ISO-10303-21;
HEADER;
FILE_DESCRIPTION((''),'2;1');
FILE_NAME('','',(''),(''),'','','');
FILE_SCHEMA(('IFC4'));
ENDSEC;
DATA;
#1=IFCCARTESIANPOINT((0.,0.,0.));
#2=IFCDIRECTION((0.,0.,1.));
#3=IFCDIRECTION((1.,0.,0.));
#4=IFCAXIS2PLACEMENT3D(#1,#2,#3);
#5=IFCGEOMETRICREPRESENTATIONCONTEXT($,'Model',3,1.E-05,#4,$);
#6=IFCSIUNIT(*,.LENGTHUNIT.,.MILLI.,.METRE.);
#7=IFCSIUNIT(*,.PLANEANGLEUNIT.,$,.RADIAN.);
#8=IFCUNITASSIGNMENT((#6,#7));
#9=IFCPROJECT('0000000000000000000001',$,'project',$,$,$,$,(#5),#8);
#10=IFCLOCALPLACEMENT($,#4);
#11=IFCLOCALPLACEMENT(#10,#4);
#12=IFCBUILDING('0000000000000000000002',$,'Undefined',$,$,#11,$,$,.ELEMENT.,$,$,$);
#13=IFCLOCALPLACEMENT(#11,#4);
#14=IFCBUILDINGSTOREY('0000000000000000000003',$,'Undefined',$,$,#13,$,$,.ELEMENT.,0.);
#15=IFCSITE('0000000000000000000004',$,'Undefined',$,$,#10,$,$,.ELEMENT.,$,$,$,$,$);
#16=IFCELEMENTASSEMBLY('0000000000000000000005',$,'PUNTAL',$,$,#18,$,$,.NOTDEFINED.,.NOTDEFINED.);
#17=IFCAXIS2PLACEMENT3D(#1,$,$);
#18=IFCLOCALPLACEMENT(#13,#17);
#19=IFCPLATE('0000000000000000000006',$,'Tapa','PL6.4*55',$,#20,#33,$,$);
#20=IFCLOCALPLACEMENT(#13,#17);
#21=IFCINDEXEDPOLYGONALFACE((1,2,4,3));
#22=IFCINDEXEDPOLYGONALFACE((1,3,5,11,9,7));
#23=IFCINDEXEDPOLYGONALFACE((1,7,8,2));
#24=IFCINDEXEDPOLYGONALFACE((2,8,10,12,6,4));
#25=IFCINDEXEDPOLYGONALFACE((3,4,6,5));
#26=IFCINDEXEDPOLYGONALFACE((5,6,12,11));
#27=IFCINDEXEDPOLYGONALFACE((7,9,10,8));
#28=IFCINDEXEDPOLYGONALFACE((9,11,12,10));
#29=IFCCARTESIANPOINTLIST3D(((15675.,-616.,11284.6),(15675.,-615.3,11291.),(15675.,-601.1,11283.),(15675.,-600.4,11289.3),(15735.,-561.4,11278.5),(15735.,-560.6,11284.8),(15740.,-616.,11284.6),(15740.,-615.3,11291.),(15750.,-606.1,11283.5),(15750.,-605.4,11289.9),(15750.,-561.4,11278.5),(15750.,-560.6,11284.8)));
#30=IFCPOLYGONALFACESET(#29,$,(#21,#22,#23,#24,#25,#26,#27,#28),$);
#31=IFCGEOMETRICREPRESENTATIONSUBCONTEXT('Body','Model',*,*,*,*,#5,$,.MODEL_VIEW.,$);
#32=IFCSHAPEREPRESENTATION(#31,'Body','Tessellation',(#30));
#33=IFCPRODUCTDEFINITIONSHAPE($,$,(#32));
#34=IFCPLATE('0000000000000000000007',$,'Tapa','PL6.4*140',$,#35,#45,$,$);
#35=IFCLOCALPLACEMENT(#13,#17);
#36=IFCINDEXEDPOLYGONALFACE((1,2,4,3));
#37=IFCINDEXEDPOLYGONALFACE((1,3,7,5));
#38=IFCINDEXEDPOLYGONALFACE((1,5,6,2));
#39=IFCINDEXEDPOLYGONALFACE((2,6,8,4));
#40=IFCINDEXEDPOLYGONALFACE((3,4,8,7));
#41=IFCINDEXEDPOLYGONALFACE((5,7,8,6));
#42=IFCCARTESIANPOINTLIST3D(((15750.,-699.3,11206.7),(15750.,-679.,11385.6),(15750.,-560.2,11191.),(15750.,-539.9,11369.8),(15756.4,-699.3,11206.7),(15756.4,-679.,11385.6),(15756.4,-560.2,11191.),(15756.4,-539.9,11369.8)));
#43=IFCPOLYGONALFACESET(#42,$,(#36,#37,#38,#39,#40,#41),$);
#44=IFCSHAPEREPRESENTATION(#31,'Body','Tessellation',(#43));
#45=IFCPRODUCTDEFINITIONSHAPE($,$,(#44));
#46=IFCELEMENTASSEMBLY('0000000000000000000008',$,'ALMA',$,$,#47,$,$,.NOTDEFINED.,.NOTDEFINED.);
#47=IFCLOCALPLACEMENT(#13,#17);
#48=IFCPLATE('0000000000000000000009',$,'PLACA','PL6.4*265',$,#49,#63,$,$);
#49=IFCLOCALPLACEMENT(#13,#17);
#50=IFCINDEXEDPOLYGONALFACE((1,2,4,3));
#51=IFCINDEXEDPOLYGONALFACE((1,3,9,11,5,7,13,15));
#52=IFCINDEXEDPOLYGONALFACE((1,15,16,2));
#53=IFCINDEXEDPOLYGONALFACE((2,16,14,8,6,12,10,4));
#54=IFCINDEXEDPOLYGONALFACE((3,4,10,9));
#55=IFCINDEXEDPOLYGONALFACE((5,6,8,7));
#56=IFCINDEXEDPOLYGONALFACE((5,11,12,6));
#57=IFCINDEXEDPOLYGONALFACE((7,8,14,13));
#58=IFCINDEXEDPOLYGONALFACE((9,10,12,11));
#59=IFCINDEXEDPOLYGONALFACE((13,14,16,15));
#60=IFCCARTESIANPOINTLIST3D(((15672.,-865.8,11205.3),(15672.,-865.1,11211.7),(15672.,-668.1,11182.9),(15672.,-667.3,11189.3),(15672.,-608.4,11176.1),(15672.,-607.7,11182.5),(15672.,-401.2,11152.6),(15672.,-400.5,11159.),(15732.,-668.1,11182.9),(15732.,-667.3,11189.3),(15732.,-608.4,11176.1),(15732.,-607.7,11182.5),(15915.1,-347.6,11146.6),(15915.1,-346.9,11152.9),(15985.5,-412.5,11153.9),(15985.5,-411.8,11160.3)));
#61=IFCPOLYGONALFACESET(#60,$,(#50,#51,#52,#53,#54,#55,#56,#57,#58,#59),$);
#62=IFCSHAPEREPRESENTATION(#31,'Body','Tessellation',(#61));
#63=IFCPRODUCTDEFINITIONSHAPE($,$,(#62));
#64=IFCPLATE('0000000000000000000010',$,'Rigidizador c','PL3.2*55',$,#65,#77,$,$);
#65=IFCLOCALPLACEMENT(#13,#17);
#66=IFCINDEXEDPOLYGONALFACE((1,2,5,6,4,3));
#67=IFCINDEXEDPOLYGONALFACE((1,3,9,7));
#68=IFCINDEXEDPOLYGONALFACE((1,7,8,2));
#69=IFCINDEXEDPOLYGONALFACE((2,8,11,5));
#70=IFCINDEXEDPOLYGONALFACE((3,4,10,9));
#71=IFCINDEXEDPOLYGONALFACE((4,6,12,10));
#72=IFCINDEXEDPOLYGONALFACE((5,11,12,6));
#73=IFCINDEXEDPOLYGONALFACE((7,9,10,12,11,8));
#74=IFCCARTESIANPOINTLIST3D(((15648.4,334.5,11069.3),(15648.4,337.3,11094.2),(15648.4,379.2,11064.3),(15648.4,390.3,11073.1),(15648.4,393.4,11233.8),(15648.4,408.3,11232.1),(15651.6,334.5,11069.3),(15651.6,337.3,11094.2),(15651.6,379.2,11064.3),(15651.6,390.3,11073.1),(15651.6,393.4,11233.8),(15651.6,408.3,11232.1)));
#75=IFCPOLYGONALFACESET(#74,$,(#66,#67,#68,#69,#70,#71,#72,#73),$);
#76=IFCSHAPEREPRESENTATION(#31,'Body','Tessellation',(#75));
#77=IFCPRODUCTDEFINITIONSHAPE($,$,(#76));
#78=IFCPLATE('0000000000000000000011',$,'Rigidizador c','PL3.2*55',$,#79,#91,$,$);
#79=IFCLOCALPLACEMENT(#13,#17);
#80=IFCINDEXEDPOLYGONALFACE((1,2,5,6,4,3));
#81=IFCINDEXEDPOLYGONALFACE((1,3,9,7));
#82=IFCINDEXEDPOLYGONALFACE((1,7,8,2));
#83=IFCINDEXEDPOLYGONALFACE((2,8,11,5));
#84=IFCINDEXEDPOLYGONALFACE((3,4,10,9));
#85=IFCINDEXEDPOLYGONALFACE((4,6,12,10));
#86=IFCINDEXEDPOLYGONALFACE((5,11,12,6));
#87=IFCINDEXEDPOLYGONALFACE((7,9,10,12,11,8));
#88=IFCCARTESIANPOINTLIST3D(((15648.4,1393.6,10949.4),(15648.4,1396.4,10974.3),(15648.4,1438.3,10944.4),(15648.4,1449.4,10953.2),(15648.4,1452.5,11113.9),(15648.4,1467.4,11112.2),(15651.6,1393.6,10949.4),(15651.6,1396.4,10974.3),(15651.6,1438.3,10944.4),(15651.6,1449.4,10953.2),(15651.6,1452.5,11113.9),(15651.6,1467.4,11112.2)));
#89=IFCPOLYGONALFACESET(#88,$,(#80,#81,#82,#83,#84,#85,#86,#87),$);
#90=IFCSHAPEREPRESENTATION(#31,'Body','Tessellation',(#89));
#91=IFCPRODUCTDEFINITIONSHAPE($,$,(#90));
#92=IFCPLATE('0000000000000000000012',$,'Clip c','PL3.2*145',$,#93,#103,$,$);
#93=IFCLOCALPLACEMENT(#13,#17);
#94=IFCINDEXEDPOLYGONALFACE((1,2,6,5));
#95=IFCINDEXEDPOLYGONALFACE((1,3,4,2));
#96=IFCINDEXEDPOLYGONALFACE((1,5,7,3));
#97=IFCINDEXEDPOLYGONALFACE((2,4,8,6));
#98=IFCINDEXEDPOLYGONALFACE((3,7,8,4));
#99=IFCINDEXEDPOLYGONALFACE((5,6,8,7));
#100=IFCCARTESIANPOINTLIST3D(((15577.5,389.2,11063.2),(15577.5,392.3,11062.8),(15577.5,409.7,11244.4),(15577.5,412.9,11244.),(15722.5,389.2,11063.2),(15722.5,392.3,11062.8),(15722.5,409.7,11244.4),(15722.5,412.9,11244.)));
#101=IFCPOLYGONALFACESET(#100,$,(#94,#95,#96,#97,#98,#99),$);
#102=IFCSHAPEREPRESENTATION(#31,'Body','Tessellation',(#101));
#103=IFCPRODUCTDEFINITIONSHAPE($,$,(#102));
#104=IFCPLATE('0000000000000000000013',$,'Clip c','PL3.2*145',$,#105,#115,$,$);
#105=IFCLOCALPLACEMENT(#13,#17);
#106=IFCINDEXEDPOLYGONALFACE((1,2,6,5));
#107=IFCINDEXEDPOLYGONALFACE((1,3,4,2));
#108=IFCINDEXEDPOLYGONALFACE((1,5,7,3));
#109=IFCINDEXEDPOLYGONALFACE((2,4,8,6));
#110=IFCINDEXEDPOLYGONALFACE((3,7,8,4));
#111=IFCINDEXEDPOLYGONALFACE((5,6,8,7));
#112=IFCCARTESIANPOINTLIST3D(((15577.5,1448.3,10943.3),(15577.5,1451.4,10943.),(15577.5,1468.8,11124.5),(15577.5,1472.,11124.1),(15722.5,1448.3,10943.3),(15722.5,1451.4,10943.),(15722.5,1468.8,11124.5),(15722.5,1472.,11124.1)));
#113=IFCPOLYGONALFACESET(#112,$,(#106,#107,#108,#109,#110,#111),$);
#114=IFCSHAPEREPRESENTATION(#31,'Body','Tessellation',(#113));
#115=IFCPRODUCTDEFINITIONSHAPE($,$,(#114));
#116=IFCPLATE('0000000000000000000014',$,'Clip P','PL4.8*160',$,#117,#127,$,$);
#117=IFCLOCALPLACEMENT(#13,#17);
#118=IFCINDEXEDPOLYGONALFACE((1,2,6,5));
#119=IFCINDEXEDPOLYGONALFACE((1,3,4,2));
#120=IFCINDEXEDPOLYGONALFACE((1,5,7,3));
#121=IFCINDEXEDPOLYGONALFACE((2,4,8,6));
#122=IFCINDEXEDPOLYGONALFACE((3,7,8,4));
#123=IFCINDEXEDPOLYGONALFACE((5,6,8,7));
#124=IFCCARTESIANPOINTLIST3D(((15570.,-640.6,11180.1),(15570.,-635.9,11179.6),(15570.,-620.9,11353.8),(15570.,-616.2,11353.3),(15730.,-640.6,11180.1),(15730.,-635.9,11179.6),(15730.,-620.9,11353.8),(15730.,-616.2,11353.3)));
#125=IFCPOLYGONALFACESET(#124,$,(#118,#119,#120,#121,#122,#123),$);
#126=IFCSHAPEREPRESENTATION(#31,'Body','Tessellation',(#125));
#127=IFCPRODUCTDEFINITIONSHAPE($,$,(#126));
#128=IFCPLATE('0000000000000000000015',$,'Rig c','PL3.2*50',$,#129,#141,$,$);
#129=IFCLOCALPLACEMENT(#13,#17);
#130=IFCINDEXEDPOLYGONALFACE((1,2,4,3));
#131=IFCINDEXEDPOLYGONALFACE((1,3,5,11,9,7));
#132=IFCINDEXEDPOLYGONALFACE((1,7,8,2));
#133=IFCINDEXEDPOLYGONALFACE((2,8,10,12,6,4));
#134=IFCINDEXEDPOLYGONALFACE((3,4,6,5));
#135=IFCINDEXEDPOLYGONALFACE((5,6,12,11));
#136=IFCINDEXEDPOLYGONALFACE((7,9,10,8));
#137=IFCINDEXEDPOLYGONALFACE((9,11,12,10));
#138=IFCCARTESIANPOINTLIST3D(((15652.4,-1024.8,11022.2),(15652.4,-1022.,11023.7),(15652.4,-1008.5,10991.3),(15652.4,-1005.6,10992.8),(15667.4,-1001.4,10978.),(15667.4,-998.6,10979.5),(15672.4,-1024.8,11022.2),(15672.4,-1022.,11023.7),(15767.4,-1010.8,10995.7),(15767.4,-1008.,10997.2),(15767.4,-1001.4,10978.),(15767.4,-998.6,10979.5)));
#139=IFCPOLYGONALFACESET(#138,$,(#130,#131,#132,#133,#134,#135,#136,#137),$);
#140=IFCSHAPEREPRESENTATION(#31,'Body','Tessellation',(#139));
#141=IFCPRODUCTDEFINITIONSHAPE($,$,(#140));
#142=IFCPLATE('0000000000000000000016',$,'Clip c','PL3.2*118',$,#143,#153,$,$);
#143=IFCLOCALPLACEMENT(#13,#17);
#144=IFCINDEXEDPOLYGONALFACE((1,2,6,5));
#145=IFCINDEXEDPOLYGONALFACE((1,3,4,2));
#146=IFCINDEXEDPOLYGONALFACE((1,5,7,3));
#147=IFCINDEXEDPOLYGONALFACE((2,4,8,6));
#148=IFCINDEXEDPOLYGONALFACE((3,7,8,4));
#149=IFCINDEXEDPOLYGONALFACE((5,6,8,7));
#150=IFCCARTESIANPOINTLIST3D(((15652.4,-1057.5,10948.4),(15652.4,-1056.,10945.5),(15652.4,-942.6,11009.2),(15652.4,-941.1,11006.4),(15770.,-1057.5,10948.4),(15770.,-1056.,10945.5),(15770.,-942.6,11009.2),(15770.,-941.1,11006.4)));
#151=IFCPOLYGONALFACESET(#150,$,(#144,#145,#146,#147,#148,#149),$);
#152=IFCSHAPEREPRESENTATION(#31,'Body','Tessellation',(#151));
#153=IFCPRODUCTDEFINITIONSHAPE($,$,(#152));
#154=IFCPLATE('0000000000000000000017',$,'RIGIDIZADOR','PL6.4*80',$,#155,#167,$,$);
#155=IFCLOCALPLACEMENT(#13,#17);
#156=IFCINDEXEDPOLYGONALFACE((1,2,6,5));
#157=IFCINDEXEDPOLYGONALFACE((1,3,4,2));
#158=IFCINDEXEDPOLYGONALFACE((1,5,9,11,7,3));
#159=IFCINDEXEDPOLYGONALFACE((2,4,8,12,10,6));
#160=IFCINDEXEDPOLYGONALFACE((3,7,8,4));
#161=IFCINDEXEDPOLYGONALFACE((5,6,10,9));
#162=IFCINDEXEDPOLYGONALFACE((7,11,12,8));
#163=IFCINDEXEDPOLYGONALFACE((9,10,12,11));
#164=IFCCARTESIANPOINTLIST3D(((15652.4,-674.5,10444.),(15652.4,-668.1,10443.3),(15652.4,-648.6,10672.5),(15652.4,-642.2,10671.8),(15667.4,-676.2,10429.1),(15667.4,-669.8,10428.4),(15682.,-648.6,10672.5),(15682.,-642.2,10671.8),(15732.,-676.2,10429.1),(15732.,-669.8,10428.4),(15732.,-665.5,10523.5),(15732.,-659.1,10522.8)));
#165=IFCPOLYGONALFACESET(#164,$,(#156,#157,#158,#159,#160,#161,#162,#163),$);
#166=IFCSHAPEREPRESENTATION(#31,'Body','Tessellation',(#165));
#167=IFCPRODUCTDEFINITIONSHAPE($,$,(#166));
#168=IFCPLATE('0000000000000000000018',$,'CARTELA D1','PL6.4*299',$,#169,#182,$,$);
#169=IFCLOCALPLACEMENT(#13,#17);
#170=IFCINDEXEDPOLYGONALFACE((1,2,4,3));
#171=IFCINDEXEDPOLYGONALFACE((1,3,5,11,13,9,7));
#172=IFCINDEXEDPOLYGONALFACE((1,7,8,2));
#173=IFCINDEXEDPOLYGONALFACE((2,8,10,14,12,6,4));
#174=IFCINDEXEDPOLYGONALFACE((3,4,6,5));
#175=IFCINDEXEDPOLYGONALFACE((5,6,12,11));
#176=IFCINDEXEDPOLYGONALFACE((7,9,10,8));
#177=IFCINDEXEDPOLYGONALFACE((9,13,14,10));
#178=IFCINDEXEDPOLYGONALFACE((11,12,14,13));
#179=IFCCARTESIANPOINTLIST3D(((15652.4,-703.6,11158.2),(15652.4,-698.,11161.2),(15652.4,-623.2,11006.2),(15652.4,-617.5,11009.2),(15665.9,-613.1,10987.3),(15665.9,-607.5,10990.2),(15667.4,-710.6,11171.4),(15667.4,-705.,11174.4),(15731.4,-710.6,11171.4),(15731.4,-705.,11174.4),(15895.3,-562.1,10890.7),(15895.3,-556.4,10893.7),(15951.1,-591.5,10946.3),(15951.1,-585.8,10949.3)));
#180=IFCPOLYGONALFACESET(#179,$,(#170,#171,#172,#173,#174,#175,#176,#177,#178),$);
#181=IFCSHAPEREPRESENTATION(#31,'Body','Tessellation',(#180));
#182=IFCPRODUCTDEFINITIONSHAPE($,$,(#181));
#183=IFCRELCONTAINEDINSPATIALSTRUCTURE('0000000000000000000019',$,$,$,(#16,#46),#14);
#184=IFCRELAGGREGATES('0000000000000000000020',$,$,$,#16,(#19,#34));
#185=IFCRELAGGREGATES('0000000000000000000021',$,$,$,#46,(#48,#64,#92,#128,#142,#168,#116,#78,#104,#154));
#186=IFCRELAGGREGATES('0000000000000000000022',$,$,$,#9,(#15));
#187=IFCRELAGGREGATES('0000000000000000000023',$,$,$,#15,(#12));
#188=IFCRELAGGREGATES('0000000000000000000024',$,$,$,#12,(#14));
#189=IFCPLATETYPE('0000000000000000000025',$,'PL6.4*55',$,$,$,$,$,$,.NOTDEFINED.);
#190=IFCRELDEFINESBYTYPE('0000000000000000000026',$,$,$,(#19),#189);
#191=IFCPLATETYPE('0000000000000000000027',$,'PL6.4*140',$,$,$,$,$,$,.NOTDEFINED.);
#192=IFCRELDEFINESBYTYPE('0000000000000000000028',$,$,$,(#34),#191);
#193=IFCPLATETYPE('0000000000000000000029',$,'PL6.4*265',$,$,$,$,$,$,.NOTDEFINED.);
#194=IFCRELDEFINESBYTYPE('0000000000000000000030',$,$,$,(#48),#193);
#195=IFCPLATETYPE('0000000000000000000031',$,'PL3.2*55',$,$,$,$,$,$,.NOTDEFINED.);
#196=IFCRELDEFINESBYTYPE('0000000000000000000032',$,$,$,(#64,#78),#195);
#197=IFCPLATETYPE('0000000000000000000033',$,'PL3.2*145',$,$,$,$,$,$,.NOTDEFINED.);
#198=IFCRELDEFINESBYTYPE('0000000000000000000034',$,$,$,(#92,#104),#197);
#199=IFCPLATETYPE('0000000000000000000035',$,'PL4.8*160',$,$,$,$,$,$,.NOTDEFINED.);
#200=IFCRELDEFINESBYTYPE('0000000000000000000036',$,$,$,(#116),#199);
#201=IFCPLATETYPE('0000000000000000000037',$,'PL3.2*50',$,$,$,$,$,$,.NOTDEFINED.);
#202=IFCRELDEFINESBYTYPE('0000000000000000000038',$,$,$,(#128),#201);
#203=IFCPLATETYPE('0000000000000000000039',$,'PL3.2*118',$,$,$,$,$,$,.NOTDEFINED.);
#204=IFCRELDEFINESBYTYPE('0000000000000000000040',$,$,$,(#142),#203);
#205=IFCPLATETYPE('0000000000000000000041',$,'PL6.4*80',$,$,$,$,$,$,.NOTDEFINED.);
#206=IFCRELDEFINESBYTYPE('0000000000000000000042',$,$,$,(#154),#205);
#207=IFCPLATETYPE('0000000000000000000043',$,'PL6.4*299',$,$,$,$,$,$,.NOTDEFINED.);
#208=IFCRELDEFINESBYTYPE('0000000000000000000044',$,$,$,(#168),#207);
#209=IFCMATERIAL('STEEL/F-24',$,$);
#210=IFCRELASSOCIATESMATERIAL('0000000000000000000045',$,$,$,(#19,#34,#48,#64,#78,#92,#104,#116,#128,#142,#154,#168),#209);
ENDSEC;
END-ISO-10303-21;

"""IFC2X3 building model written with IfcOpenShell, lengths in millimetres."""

from ifc_helpers import new_model, si_unit, frame, origin_with_axes, place, context, subcontext, project, spatial, polyline, outline, extrude, boolean, material, type_object, element, aggregate, save


model = new_model("IFC2X3")

# Units and contexts
model_context = context("Model", 3, precision=1e-05, world=origin_with_axes())
body_context = subcontext(model_context, "Body", "Model", "MODEL_VIEW")
ifc_project = project(units=[si_unit("LENGTHUNIT", "METRE", prefix="MILLI"), si_unit("PLANEANGLEUNIT", "RADIAN")], contexts=[model_context])

# Site, building, storey
site_placement = place(None, origin_with_axes())
site = spatial("IfcSite", under=ifc_project, at=site_placement, Name="Undefined", CompositionType="ELEMENT")
building_placement = place(site_placement, origin_with_axes())
building = spatial("IfcBuilding", under=site, at=building_placement, Name="Undefined", CompositionType="ELEMENT")
storey_placement = place(building_placement, origin_with_axes())
storey = spatial("IfcBuildingStorey", under=building, at=storey_placement, Name="Undefined", CompositionType="ELEMENT", Elevation=0.0)

# Shared definitions
ifc_material_1 = material(Name="STEEL/F-24")

# Element assemblies, plates
assembly_1_placement = place(storey_placement, origin_with_axes())
assembly_1 = element("IfcElementAssembly", 1, at=assembly_1_placement, inside=storey, Name="PUNTAL", AssemblyPlace="NOTDEFINED", PredefinedType="NOTDEFINED")
plate_type_1 = type_object("IfcPlateType", Name="PL6.4*55", PredefinedType="NOTDEFINED")
plate_1_placement = place(assembly_1_placement, frame((15675.0, -615.7, 11287.8), z_axis=(0.0, 0.112644, 0.993635), x_axis=(1.0, 0.0, 0.0)))
plate_1 = element("IfcPlate", 2, at=plate_1_placement, type_object=plate_type_1, material=ifc_material_1, Name="Tapa", Description="PL6.4*55", context=body_context, shape_type="SweptSolid", body=[
    extrude(outline(polyline([(0.0, 0.0), (65.0, 0.0), (75.0, 10.0), (75.0, 55.0), (60.0, 55.0), (0.0, 15.0), (0.0, 0.0)])), frame((0.0, 0.0, -3.2), z_axis=(0.0, 0.0, 1.0), x_axis=(1.0, 0.0, 0.0)), (0.0, 0.0, 1.0), 6.4),
])
plate_type_2 = type_object("IfcPlateType", Name="PL6.4*140", PredefinedType="NOTDEFINED")
plate_2_placement = place(assembly_1_placement, frame((15753.2, -539.9, 11369.8), z_axis=(1.0, 0.0, 0.0), x_axis=(0.0, -0.993635, 0.112644)))
plate_2 = element("IfcPlate", 3, at=plate_2_placement, type_object=plate_type_2, material=ifc_material_1, Name="Tapa", Description="PL6.4*140", context=body_context, shape_type="SweptSolid", body=[
    extrude(outline(polyline([(0.0, 0.0), (140.0, 0.0), (140.0, 180.0), (0.0, 180.0), (0.0, 0.0)])), frame((0.0, 0.0, -3.2), z_axis=(0.0, 0.0, 1.0), x_axis=(1.0, 0.0, 0.0)), (0.0, 0.0, 1.0), 6.4),
])
aggregate(assembly_1, [plate_1, plate_2])
assembly_2_placement = place(storey_placement, origin_with_axes())
assembly_2 = element("IfcElementAssembly", 4, at=assembly_2_placement, inside=storey, Name="ALMA", AssemblyPlace="NOTDEFINED", PredefinedType="NOTDEFINED")
plate_type_3 = type_object("IfcPlateType", Name="PL6.4*265", PredefinedType="NOTDEFINED")
plate_3_placement = place(assembly_2_placement, frame((15672.0, -400.9, 11155.8), z_axis=(-0.000026, 0.112723, 0.993626), x_axis=(0.0, -0.993626, 0.112723)))
plate_3 = element("IfcPlate", 5, at=plate_3_placement, type_object=plate_type_3, material=ifc_material_1, Name="PLACA", Description="PL6.4*265", context=body_context, shape_type="CSG", body=[
    boolean("DIFFERENCE", extrude(outline(polyline([(0.0, 0.0), (467.5, 0.0), (11.4, 313.5), (-53.9, 243.1), (0.0, 0.0)])), frame((0.0, 0.0, -3.2), z_axis=(0.0, 0.0, 1.0), x_axis=(1.0, 0.0, 0.0)), (0.0, 0.0, 1.0), 6.4), extrude(outline(polyline([(0.0, 0.0), (60.0, 0.0), (60.0, 60.0), (0.0, 60.0), (0.0, 0.0)])), frame((208.6, 0.0, 4.6), z_axis=(-0.000328, -0.000026, -1.0), x_axis=(0.0, 1.0, -0.000026)), (0.0, 0.0, 1.0), 12.0)),
])
plate_type_4 = type_object("IfcPlateType", Name="PL3.2*55", PredefinedType="NOTDEFINED")
plate_4_placement = place(assembly_2_placement, frame((15650.0, 408.3, 11232.1), z_axis=(1.0, 0.0, 0.0), x_axis=(0.0, -0.993635, 0.112644)))
plate_4 = element("IfcPlate", 6, at=plate_4_placement, type_object=plate_type_4, material=ifc_material_1, Name="Rigidizador c", Description="PL3.2*55", context=body_context, shape_type="SweptSolid", body=[
    extrude(outline(polyline([(0.0, 0.0), (15.0, 0.0), (55.0, 145.0), (55.0, 170.1), (10.0, 170.0), (0.0, 160.0), (0.0, 0.0)])), frame((0.0, 0.0, -1.6), z_axis=(0.0, 0.0, 1.0), x_axis=(1.0, 0.0, 0.0)), (0.0, 0.0, 1.0), 3.2),
])
plate_5_placement = place(assembly_2_placement, frame((15650.0, 1467.4, 11112.2), z_axis=(1.0, 0.0, 0.0), x_axis=(0.0, -0.993635, 0.112644)))
plate_5 = element("IfcPlate", 7, at=plate_5_placement, type_object=plate_type_4, material=ifc_material_1, Name="Rigidizador c", Description="PL3.2*55", context=body_context, shape_type="SweptSolid", body=[
    extrude(outline(polyline([(0.0, 0.0), (15.0, 0.0), (55.0, 145.0), (55.0, 170.1), (10.0, 170.0), (0.0, 160.0), (0.0, 0.0)])), frame((0.0, 0.0, -1.6), z_axis=(0.0, 0.0, 1.0), x_axis=(1.0, 0.0, 0.0)), (0.0, 0.0, 1.0), 3.2),
])
plate_type_5 = type_object("IfcPlateType", Name="PL3.2*145", PredefinedType="NOTDEFINED")
plate_6_placement = place(assembly_2_placement, frame((15722.5, 390.8, 11063.0), z_axis=(0.0, -0.993645, 0.112559), x_axis=(0.0, 0.112559, 0.993645)))
plate_6 = element("IfcPlate", 8, at=plate_6_placement, type_object=plate_type_5, material=ifc_material_1, Name="Clip c", Description="PL3.2*145", context=body_context, shape_type="SweptSolid", body=[
    extrude(outline(polyline([(0.0, 0.0), (182.3, 0.0), (182.3, 145.0), (0.0, 145.0), (0.0, 0.0)])), frame((0.0, 0.0, -1.6), z_axis=(0.0, 0.0, 1.0), x_axis=(1.0, 0.0, 0.0)), (0.0, 0.0, 1.0), 3.2),
])
plate_7_placement = place(assembly_2_placement, frame((15722.5, 1449.9, 10943.1), z_axis=(0.0, -0.993645, 0.112559), x_axis=(0.0, 0.112559, 0.993645)))
plate_7 = element("IfcPlate", 9, at=plate_7_placement, type_object=plate_type_5, material=ifc_material_1, Name="Clip c", Description="PL3.2*145", context=body_context, shape_type="SweptSolid", body=[
    extrude(outline(polyline([(0.0, 0.0), (182.3, 0.0), (182.3, 145.0), (0.0, 145.0), (0.0, 0.0)])), frame((0.0, 0.0, -1.6), z_axis=(0.0, 0.0, 1.0), x_axis=(1.0, 0.0, 0.0)), (0.0, 0.0, 1.0), 3.2),
])
plate_type_6 = type_object("IfcPlateType", Name="PL4.8*160", PredefinedType="NOTDEFINED")
plate_8_placement = place(assembly_2_placement, frame((15730.0, -638.2, 11179.8), z_axis=(0.0, -0.993645, 0.112555), x_axis=(0.0, 0.112555, 0.993645)))
plate_8 = element("IfcPlate", 10, at=plate_8_placement, type_object=plate_type_6, material=ifc_material_1, Name="Clip P", Description="PL4.8*160", context=body_context, shape_type="SweptSolid", body=[
    extrude(outline(polyline([(0.0, 0.0), (174.8, 0.0), (174.8, 160.0), (0.0, 160.0), (0.0, 0.0)])), frame((0.0, 0.0, -2.4), z_axis=(0.0, 0.0, 1.0), x_axis=(1.0, 0.0, 0.0)), (0.0, 0.0, 1.0), 4.8),
])
plate_type_7 = type_object("IfcPlateType", Name="PL3.2*50", PredefinedType="NOTDEFINED")
plate_9_placement = place(assembly_2_placement, frame((15767.4, -1000.0, 10978.8), z_axis=(0.0, 0.883788, 0.467888), x_axis=(-1.0, 0.0, 0.0)))
plate_9 = element("IfcPlate", 11, at=plate_9_placement, type_object=plate_type_7, material=ifc_material_1, Name="Rig c", Description="PL3.2*50", context=body_context, shape_type="SweptSolid", body=[
    extrude(outline(polyline([(0.0, 0.0), (100.0, 0.0), (115.0, 15.0), (115.0, 50.0), (95.0, 50.0), (0.0, 20.0), (0.0, 0.0)])), frame((0.0, 0.0, -1.6), z_axis=(0.0, 0.0, 1.0), x_axis=(1.0, 0.0, 0.0)), (0.0, 0.0, 1.0), 3.2),
])
plate_type_8 = type_object("IfcPlateType", Name="PL3.2*118", PredefinedType="NOTDEFINED")
plate_10_placement = place(assembly_2_placement, frame((15652.4, -941.8, 11007.8), z_axis=(0.0, -0.467888, 0.883788), x_axis=(0.0, -0.883788, -0.467888)))
plate_10 = element("IfcPlate", 12, at=plate_10_placement, type_object=plate_type_8, material=ifc_material_1, Name="Clip c", Description="PL3.2*118", context=body_context, shape_type="SweptSolid", body=[
    extrude(outline(polyline([(0.0, 0.0), (130.0, 0.0), (130.0, 117.6), (0.0, 117.6), (0.0, 0.0)])), frame((0.0, 0.0, -1.6), z_axis=(0.0, 0.0, 1.0), x_axis=(1.0, 0.0, 0.0)), (0.0, 0.0, 1.0), 3.2),
])
plate_type_9 = type_object("IfcPlateType", Name="PL6.4*80", PredefinedType="NOTDEFINED")
plate_11_placement = place(assembly_2_placement, frame((15732.0, -645.4, 10672.2), z_axis=(0.0, 0.993636, -0.112642), x_axis=(0.0, -0.112642, -0.993636)))
plate_11 = element("IfcPlate", 13, at=plate_11_placement, type_object=plate_type_9, material=ifc_material_1, Name="RIGIDIZADOR", Description="PL6.4*80", context=body_context, shape_type="SweptSolid", body=[
    extrude(outline(polyline([(0.0, 50.0), (150.0, 0.0), (245.0, 0.0), (245.0, 64.6), (230.0, 79.6), (0.0, 79.6), (0.0, 50.0)])), frame((0.0, 0.0, -3.2), z_axis=(0.0, 0.0, 1.0), x_axis=(1.0, 0.0, 0.0)), (0.0, 0.0, 1.0), 6.4),
])
plate_type_10 = type_object("IfcPlateType", Name="PL6.4*299", PredefinedType="NOTDEFINED")
plate_12_placement = place(assembly_2_placement, frame((15652.4, -707.8, 11172.9), z_axis=(0.0, -0.883815, -0.467837), x_axis=(0.0, 0.467837, -0.883815)))
plate_12 = element("IfcPlate", 14, at=plate_12_placement, type_object=plate_type_10, material=ifc_material_1, Name="CARTELA D1", Description="PL6.4*299", context=body_context, shape_type="SweptSolid", body=[
    extrude(outline(polyline([(0.0, 15.0), (15.0, 0.0), (187.0, 0.0), (208.4, 13.5), (317.6, 242.9), (254.8, 298.7), (0.0, 79.0), (0.0, 15.0)])), frame((0.0, 0.0, -3.2), z_axis=(0.0, 0.0, 1.0), x_axis=(1.0, 0.0, 0.0)), (0.0, 0.0, 1.0), 6.4),
])

aggregate(assembly_2, [plate_3, plate_4, plate_6, plate_9, plate_10, plate_12, plate_8, plate_5, plate_7, plate_11])

save(model, "model.ifc")
